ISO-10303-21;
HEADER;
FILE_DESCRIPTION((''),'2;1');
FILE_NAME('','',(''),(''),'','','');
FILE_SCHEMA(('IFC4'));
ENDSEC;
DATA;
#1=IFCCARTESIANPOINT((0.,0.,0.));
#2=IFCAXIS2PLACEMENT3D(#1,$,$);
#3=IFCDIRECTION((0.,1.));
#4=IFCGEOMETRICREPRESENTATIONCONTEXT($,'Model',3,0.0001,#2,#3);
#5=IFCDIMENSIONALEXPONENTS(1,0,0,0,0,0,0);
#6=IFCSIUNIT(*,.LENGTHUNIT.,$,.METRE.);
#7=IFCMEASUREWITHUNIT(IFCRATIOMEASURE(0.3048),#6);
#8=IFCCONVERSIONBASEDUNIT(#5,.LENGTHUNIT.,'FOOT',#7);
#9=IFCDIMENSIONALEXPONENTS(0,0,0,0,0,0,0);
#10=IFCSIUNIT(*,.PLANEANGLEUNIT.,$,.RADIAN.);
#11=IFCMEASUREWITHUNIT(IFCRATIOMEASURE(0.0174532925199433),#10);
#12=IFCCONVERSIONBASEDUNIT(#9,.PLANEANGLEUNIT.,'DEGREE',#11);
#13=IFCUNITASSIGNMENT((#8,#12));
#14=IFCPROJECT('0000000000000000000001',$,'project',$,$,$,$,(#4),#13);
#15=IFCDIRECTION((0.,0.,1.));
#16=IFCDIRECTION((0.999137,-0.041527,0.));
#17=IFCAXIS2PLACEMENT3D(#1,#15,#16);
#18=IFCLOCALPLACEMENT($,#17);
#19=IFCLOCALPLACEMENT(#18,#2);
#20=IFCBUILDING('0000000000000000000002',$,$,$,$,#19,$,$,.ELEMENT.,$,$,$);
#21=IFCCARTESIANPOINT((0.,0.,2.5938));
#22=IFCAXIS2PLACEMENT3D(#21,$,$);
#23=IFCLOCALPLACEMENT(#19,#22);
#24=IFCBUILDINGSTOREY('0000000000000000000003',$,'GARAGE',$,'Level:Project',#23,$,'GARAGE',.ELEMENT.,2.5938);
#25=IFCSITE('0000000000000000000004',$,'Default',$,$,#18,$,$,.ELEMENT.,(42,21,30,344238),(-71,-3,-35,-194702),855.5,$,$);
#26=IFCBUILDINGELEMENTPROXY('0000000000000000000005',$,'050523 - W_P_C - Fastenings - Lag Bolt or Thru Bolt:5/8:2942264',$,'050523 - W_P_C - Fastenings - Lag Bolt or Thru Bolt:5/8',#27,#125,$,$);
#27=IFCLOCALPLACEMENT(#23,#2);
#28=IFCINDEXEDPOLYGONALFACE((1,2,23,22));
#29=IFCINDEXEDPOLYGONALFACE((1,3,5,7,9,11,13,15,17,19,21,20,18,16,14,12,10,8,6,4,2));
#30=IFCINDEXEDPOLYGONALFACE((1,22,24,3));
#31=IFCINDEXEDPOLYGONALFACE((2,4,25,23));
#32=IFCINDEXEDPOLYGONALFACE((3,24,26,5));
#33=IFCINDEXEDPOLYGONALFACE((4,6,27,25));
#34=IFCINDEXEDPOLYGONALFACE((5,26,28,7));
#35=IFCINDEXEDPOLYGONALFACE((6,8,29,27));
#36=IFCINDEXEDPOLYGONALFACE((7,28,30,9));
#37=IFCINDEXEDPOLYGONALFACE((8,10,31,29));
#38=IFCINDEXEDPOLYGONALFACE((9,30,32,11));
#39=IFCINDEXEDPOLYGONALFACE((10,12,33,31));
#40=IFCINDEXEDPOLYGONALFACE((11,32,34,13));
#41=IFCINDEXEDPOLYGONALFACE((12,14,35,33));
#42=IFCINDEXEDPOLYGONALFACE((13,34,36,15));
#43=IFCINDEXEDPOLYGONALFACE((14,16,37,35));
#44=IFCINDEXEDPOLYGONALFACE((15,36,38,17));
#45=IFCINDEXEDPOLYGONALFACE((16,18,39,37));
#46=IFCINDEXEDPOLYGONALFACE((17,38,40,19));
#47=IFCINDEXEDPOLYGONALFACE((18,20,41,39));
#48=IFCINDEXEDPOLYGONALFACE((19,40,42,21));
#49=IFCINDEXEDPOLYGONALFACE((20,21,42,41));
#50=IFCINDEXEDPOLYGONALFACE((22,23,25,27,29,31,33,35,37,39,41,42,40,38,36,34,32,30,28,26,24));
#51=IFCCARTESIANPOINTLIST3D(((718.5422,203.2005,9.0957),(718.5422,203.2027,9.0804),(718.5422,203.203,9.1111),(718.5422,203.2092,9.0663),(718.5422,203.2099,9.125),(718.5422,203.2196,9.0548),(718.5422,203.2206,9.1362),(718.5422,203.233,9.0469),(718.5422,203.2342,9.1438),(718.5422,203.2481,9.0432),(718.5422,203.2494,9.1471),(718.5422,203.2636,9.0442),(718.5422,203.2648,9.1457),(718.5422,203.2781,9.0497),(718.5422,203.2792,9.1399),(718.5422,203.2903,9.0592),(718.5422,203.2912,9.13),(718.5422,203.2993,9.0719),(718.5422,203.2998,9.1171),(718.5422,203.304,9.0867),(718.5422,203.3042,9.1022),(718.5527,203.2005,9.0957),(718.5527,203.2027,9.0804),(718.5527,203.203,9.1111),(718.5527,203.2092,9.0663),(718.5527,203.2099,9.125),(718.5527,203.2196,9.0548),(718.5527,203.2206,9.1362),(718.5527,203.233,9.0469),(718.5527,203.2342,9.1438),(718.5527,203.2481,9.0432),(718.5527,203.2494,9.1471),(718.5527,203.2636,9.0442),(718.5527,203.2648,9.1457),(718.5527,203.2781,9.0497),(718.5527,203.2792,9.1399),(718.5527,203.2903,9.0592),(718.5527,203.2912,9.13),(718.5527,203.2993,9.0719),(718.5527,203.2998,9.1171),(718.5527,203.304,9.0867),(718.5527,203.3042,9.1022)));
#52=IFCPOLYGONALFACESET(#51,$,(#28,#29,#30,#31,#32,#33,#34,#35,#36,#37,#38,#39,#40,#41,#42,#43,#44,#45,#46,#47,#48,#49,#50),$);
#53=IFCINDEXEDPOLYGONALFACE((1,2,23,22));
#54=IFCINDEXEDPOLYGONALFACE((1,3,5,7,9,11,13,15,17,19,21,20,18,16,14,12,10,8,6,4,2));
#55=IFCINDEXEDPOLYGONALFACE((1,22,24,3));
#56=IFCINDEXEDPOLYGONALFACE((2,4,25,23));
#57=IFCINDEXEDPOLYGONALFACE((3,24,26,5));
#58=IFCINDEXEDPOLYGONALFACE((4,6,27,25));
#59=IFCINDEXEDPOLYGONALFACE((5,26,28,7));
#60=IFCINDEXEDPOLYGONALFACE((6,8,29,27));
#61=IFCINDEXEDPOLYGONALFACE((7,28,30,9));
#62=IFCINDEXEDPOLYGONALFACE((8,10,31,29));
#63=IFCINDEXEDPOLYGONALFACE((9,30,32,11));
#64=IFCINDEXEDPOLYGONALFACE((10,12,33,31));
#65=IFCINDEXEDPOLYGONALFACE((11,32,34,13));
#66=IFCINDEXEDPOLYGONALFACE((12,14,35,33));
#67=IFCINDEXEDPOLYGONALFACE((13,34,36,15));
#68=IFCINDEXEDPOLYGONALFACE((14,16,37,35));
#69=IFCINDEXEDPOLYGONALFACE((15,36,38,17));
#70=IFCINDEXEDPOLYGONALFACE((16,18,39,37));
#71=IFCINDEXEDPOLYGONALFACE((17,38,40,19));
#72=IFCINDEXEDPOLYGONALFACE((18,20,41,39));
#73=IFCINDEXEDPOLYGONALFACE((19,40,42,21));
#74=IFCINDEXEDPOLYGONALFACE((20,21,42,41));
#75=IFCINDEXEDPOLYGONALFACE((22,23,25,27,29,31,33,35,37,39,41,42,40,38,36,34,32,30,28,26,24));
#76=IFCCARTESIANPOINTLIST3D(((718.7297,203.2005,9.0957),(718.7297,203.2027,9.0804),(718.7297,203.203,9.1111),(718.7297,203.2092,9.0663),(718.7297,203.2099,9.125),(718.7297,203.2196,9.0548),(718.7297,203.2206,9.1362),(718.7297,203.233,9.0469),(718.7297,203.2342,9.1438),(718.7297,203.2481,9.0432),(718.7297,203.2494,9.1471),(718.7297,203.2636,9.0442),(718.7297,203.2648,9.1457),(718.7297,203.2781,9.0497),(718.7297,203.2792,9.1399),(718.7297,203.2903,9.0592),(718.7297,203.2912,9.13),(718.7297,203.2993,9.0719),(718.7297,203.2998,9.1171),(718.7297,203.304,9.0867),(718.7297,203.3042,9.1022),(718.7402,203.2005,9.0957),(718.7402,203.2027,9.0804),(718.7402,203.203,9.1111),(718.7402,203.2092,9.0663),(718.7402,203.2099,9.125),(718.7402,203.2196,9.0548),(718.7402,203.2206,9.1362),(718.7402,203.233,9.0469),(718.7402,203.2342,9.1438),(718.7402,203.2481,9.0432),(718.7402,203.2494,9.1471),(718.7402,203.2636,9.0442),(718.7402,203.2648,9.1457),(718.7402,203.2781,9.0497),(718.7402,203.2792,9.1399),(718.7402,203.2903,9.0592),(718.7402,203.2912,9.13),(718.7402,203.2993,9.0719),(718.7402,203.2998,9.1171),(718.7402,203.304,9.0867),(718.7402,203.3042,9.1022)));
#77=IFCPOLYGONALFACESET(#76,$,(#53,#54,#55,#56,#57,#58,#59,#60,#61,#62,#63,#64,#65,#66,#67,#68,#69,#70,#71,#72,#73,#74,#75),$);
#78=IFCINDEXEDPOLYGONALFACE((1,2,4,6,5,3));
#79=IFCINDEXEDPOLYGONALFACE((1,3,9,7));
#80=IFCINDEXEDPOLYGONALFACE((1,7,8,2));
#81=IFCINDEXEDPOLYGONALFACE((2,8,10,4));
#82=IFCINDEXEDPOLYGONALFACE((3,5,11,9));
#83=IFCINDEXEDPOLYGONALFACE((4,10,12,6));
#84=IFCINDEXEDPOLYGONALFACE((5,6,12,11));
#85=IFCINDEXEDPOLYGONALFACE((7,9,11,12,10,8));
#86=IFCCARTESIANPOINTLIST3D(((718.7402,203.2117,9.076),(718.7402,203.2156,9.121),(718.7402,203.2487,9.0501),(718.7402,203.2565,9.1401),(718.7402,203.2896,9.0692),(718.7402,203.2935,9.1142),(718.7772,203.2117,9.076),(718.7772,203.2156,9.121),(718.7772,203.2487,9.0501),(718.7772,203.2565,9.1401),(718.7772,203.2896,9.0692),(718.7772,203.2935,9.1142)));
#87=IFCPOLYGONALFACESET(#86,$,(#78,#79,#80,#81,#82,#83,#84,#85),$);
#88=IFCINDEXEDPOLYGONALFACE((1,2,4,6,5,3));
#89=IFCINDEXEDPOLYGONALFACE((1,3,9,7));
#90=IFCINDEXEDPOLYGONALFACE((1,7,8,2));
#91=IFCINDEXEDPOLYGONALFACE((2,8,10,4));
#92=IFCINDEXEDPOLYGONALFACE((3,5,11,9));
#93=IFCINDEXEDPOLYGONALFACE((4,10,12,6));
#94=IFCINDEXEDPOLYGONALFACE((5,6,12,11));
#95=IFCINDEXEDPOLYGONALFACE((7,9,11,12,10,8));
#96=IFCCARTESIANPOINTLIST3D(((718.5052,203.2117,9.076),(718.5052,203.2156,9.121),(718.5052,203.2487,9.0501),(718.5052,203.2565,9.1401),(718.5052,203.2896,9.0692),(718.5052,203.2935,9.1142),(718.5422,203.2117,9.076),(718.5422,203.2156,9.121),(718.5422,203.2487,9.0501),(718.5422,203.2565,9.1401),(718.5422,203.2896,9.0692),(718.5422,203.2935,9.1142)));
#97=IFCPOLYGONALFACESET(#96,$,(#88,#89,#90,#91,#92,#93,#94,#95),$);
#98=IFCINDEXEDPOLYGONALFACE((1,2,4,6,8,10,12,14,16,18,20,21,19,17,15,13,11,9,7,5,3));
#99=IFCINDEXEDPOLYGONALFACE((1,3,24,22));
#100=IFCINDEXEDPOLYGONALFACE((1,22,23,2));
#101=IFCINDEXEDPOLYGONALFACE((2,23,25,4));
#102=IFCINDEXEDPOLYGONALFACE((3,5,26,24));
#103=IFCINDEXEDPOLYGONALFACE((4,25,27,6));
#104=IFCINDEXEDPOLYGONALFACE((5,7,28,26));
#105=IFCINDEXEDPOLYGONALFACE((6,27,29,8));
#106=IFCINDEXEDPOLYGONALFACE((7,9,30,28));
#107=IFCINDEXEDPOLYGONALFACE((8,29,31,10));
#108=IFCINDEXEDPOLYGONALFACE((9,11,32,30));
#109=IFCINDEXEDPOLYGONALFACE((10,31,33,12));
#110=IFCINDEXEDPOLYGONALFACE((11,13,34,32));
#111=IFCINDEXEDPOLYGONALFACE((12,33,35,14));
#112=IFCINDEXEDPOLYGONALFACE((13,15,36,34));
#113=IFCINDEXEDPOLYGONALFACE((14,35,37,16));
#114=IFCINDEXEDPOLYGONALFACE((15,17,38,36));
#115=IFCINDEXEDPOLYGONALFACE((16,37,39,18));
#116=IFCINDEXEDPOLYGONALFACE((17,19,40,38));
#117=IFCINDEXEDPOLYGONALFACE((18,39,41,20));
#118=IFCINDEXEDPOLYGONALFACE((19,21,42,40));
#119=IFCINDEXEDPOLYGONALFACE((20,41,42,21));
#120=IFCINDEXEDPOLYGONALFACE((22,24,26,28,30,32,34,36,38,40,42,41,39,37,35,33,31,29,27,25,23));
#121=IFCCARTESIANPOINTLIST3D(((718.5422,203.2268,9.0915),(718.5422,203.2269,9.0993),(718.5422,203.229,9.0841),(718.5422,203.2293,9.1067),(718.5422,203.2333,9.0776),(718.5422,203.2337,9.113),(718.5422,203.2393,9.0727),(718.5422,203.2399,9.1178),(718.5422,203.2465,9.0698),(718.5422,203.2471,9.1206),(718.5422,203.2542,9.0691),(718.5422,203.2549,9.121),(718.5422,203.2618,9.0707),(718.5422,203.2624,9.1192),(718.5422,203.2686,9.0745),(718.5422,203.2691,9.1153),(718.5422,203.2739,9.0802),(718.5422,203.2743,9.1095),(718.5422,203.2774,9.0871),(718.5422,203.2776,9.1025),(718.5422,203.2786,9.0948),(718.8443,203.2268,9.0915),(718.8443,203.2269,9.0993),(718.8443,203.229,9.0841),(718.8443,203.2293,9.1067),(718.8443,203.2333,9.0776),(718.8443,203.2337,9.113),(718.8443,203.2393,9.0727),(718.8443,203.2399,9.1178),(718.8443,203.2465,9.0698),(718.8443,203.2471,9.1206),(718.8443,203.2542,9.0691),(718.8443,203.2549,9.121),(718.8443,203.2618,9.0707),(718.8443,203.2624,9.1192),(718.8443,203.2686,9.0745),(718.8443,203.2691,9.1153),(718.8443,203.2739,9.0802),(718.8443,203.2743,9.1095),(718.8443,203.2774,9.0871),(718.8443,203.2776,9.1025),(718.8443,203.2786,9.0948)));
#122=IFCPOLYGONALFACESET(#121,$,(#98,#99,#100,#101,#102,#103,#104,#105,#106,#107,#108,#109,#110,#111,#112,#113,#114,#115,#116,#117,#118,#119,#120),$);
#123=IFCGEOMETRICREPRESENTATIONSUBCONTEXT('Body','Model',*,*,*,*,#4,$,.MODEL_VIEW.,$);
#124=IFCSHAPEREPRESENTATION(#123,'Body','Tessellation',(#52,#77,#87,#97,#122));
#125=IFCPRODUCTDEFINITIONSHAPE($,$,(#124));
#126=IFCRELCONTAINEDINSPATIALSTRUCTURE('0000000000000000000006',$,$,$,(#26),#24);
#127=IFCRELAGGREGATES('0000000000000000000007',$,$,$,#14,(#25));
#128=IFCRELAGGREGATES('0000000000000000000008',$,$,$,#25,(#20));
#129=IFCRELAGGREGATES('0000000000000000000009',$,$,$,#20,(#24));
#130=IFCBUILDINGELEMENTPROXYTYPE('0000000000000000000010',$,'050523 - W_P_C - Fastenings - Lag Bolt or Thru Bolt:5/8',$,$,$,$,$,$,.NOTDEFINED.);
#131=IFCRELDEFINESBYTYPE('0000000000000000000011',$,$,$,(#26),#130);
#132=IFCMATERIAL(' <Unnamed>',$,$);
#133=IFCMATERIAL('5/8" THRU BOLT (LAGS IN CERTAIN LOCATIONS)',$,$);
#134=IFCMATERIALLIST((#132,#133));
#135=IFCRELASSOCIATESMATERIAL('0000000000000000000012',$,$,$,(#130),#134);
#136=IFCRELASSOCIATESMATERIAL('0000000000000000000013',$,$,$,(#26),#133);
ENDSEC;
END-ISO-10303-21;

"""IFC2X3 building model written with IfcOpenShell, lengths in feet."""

from ifc_helpers import new_model, entity, si_unit, converted_unit, direction, frame, frame_2d, origin, place, context, subcontext, project, spatial, polyline, circle, outline, extrude, source, transform, mapped, material, material_list, type_object, type_shapes, element, save


model = new_model("IFC2X3")

# Units and contexts
model_context = context("Model", 3, precision=0.0001, world=origin(), true_north=direction((0.0, 1.0)))
body_context = subcontext(model_context, "Body", "Model", "MODEL_VIEW")
ifc_project = project(units=[converted_unit("LENGTHUNIT", "FOOT", entity("IfcRatioMeasure", 0.3048), si_unit("LENGTHUNIT", "METRE"), dimensions=[1, 0, 0, 0, 0, 0, 0]), converted_unit("PLANEANGLEUNIT", "DEGREE", entity("IfcRatioMeasure", 0.0174532925199433), si_unit("PLANEANGLEUNIT", "RADIAN"), dimensions=[0, 0, 0, 0, 0, 0, 0])], contexts=[model_context])

# Site, building, storey
site_placement = place(None, frame((0.0, 0.0, 0.0), z_axis=(0.0, 0.0, 1.0), x_axis=(0.999137, -0.041527, 0.0)))
site = spatial("IfcSite", under=ifc_project, at=site_placement, Name="Default", CompositionType="ELEMENT", RefLatitude=(42, 21, 30, 344238), RefLongitude=(-71, -3, -35, -194702), RefElevation=855.5)
building_placement = place(site_placement, origin())
building = spatial("IfcBuilding", under=site, at=building_placement, CompositionType="ELEMENT")
storey_placement = place(building_placement, frame((0.0, 0.0, 2.5938)))
storey = spatial("IfcBuildingStorey", under=building, at=storey_placement, Name="GARAGE", ObjectType="Level:Project", LongName="GARAGE", CompositionType="ELEMENT", Elevation=2.5938)

# Building element proxy
ifc_material_1 = material(Name="5/8\" THRU BOLT (LAGS IN CERTAIN LOCATIONS)")
ifc_material_2 = material(Name=" <Unnamed>")
ifc_material_list_1 = material_list([ifc_material_2, ifc_material_1])
building_element_proxy_type_1 = type_object("IfcBuildingElementProxyType", Name="050523 - W_P_C - Fastenings - Lag Bolt or Thru Bolt:5/8", PredefinedType="NOTDEFINED", material=ifc_material_list_1)
shared_shape_1 = source(origin(), body_context, "Body", "SweptSolid", [
    extrude(circle(Radius=0.0521, at=frame_2d((0.0, 0.0), x_axis=(1.0, 0.0))), frame((0.0, 0.0, 0.0), z_axis=(0.0, 0.0, 1.0), x_axis=(0.0, 1.0, 0.0)), (0.0, 0.0, 1.0), 0.0104),
    extrude(circle(Radius=0.0521, at=frame_2d((0.0, 0.0), x_axis=(1.0, 0.0))), frame((0.0, 0.0, -0.1875), z_axis=(0.0, 0.0, 1.0), x_axis=(0.0, 1.0, 0.0)), (0.0, 0.0, 1.0), 0.0104),
    extrude(outline(polyline([(-0.0226, -0.0391), (0.0226, -0.0391), (0.0451, 0.0), (0.0226, 0.0391), (-0.0226, 0.0391), (-0.0451, 0.0), (-0.0226, -0.0391)])), frame((0.0, 0.0, -0.2245), z_axis=(0.0, 0.0, 1.0), x_axis=(0.0, -1.0, 0.0)), (0.0, 0.0, 1.0), 0.037),
    extrude(outline(polyline([(-0.0226, -0.0391), (0.0226, -0.0391), (0.0451, 0.0), (0.0226, 0.0391), (-0.0226, 0.0391), (-0.0451, 0.0), (-0.0226, -0.0391)])), frame((0.0, 0.0, 0.0104), z_axis=(0.0, 0.0, 1.0), x_axis=(0.866025, -0.5, 0.0)), (0.0, 0.0, 1.0), 0.037),
    extrude(circle(Radius=0.026, at=frame_2d((0.0, 0.0), x_axis=(1.0, 0.0))), frame((0.0, 0.0, -0.2917), z_axis=(0.0, 0.0, 1.0), x_axis=(0.0, -1.0, 0.0)), (0.0, 0.0, 1.0), 0.3021),
])
type_shapes(building_element_proxy_type_1, [shared_shape_1])
for number, where, z_axis, x_axis, name in (
    (1, (718.5527, 203.2526, 9.0951), (-1.0, 0.0, 0.0), (0.0, 0.996195, -0.087156), "050523 - W_P_C - Fastenings - Lag Bolt or Thru Bolt:5/8:2942264"),
):
    element("IfcBuildingElementProxy", number, at=place(storey_placement, frame(where, z_axis=z_axis, x_axis=x_axis)), inside=storey, type_object=building_element_proxy_type_1, material=ifc_material_1, Name=name, ObjectType="050523 - W_P_C - Fastenings - Lag Bolt or Thru Bolt:5/8", context=body_context, shape_type="MappedRepresentation", body=[
        mapped(shared_shape_1, transform((0.0, 0.0, 0.0), scale=1.0)),
    ])

save(model, "model.ifc")
